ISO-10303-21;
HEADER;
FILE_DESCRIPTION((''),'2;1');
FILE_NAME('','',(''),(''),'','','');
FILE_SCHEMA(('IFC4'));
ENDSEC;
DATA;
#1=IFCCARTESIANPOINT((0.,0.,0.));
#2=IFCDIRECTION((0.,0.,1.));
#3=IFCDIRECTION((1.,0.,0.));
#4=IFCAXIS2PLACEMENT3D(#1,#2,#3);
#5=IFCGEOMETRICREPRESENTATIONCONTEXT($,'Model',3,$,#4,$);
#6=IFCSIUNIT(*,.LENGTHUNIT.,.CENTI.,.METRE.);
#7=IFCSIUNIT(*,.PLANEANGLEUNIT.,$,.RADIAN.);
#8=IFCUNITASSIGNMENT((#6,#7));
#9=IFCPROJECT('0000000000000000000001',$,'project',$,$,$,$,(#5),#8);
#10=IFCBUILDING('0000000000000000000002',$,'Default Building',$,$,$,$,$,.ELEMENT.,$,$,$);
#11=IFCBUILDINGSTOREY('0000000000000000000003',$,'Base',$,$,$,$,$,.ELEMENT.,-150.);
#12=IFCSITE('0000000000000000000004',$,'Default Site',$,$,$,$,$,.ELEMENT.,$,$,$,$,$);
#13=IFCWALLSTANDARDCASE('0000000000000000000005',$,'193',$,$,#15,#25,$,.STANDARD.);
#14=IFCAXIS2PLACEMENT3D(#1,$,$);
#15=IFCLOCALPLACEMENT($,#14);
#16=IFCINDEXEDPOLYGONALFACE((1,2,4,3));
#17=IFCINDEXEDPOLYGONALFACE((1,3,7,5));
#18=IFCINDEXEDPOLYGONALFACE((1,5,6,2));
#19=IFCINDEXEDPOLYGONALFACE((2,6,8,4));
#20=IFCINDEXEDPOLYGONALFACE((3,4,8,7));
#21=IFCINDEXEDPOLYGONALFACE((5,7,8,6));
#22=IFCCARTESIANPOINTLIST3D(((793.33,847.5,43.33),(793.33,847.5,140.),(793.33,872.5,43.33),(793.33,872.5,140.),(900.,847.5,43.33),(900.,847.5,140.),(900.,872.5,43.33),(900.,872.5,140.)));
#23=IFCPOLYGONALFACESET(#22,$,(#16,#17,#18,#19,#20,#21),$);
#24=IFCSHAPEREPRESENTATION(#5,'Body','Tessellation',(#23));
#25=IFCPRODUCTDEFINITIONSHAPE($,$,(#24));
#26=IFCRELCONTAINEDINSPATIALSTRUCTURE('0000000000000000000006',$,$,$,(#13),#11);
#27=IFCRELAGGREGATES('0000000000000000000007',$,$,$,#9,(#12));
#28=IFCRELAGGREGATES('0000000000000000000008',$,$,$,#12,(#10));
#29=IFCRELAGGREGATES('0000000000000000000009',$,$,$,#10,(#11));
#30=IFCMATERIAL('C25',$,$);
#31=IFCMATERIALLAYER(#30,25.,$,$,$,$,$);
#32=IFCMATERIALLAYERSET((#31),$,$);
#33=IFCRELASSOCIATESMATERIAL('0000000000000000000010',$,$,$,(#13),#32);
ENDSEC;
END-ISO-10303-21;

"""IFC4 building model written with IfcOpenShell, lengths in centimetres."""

from ifc_helpers import new_model, si_unit, frame, origin_with_axes, origin_2d_with_axis, place, context, project, spatial, rectangle, extrude, material, layer, layer_set, layer_usage, element, save


model = new_model("IFC4")

# Units and contexts
model_context = context("Model", 3, world=origin_with_axes())
ifc_project = project(units=[si_unit("LENGTHUNIT", "METRE", prefix="CENTI"), si_unit("PLANEANGLEUNIT", "RADIAN")], contexts=[model_context])

# Site, building, storey
site = spatial("IfcSite", under=ifc_project, Name="Default Site", CompositionType="ELEMENT")
building = spatial("IfcBuilding", under=site, Name="Default Building", CompositionType="ELEMENT")
storey = spatial("IfcBuildingStorey", under=building, Name="Base", CompositionType="ELEMENT", Elevation=-150.0)

# Shared definitions
ifc_material = material(Name="C25")

# Wall
ifc_layer_1 = layer(ifc_material, 25.0)
ifc_layer_set_1 = layer_set([ifc_layer_1])
ifc_layer_usage_1 = layer_usage(ifc_layer_set_1, "AXIS2", "POSITIVE", -25.0)
wall_1_placement = place(None, frame((846.67, 860.0, 43.33), z_axis=(0.0, 0.0, 1.0), x_axis=(1.0, 0.0, 0.0)))
element("IfcWallStandardCase", 1, at=wall_1_placement, inside=storey, material=ifc_layer_usage_1, Name="193", PredefinedType="STANDARD", context=model_context, shape_type="SweptSolid", body=[
    extrude(rectangle(XDim=106.67, YDim=25.0, at=origin_2d_with_axis()), origin_with_axes(), (0.0, 0.0, 1.0), 96.67),
])

save(model, "model.ifc")
